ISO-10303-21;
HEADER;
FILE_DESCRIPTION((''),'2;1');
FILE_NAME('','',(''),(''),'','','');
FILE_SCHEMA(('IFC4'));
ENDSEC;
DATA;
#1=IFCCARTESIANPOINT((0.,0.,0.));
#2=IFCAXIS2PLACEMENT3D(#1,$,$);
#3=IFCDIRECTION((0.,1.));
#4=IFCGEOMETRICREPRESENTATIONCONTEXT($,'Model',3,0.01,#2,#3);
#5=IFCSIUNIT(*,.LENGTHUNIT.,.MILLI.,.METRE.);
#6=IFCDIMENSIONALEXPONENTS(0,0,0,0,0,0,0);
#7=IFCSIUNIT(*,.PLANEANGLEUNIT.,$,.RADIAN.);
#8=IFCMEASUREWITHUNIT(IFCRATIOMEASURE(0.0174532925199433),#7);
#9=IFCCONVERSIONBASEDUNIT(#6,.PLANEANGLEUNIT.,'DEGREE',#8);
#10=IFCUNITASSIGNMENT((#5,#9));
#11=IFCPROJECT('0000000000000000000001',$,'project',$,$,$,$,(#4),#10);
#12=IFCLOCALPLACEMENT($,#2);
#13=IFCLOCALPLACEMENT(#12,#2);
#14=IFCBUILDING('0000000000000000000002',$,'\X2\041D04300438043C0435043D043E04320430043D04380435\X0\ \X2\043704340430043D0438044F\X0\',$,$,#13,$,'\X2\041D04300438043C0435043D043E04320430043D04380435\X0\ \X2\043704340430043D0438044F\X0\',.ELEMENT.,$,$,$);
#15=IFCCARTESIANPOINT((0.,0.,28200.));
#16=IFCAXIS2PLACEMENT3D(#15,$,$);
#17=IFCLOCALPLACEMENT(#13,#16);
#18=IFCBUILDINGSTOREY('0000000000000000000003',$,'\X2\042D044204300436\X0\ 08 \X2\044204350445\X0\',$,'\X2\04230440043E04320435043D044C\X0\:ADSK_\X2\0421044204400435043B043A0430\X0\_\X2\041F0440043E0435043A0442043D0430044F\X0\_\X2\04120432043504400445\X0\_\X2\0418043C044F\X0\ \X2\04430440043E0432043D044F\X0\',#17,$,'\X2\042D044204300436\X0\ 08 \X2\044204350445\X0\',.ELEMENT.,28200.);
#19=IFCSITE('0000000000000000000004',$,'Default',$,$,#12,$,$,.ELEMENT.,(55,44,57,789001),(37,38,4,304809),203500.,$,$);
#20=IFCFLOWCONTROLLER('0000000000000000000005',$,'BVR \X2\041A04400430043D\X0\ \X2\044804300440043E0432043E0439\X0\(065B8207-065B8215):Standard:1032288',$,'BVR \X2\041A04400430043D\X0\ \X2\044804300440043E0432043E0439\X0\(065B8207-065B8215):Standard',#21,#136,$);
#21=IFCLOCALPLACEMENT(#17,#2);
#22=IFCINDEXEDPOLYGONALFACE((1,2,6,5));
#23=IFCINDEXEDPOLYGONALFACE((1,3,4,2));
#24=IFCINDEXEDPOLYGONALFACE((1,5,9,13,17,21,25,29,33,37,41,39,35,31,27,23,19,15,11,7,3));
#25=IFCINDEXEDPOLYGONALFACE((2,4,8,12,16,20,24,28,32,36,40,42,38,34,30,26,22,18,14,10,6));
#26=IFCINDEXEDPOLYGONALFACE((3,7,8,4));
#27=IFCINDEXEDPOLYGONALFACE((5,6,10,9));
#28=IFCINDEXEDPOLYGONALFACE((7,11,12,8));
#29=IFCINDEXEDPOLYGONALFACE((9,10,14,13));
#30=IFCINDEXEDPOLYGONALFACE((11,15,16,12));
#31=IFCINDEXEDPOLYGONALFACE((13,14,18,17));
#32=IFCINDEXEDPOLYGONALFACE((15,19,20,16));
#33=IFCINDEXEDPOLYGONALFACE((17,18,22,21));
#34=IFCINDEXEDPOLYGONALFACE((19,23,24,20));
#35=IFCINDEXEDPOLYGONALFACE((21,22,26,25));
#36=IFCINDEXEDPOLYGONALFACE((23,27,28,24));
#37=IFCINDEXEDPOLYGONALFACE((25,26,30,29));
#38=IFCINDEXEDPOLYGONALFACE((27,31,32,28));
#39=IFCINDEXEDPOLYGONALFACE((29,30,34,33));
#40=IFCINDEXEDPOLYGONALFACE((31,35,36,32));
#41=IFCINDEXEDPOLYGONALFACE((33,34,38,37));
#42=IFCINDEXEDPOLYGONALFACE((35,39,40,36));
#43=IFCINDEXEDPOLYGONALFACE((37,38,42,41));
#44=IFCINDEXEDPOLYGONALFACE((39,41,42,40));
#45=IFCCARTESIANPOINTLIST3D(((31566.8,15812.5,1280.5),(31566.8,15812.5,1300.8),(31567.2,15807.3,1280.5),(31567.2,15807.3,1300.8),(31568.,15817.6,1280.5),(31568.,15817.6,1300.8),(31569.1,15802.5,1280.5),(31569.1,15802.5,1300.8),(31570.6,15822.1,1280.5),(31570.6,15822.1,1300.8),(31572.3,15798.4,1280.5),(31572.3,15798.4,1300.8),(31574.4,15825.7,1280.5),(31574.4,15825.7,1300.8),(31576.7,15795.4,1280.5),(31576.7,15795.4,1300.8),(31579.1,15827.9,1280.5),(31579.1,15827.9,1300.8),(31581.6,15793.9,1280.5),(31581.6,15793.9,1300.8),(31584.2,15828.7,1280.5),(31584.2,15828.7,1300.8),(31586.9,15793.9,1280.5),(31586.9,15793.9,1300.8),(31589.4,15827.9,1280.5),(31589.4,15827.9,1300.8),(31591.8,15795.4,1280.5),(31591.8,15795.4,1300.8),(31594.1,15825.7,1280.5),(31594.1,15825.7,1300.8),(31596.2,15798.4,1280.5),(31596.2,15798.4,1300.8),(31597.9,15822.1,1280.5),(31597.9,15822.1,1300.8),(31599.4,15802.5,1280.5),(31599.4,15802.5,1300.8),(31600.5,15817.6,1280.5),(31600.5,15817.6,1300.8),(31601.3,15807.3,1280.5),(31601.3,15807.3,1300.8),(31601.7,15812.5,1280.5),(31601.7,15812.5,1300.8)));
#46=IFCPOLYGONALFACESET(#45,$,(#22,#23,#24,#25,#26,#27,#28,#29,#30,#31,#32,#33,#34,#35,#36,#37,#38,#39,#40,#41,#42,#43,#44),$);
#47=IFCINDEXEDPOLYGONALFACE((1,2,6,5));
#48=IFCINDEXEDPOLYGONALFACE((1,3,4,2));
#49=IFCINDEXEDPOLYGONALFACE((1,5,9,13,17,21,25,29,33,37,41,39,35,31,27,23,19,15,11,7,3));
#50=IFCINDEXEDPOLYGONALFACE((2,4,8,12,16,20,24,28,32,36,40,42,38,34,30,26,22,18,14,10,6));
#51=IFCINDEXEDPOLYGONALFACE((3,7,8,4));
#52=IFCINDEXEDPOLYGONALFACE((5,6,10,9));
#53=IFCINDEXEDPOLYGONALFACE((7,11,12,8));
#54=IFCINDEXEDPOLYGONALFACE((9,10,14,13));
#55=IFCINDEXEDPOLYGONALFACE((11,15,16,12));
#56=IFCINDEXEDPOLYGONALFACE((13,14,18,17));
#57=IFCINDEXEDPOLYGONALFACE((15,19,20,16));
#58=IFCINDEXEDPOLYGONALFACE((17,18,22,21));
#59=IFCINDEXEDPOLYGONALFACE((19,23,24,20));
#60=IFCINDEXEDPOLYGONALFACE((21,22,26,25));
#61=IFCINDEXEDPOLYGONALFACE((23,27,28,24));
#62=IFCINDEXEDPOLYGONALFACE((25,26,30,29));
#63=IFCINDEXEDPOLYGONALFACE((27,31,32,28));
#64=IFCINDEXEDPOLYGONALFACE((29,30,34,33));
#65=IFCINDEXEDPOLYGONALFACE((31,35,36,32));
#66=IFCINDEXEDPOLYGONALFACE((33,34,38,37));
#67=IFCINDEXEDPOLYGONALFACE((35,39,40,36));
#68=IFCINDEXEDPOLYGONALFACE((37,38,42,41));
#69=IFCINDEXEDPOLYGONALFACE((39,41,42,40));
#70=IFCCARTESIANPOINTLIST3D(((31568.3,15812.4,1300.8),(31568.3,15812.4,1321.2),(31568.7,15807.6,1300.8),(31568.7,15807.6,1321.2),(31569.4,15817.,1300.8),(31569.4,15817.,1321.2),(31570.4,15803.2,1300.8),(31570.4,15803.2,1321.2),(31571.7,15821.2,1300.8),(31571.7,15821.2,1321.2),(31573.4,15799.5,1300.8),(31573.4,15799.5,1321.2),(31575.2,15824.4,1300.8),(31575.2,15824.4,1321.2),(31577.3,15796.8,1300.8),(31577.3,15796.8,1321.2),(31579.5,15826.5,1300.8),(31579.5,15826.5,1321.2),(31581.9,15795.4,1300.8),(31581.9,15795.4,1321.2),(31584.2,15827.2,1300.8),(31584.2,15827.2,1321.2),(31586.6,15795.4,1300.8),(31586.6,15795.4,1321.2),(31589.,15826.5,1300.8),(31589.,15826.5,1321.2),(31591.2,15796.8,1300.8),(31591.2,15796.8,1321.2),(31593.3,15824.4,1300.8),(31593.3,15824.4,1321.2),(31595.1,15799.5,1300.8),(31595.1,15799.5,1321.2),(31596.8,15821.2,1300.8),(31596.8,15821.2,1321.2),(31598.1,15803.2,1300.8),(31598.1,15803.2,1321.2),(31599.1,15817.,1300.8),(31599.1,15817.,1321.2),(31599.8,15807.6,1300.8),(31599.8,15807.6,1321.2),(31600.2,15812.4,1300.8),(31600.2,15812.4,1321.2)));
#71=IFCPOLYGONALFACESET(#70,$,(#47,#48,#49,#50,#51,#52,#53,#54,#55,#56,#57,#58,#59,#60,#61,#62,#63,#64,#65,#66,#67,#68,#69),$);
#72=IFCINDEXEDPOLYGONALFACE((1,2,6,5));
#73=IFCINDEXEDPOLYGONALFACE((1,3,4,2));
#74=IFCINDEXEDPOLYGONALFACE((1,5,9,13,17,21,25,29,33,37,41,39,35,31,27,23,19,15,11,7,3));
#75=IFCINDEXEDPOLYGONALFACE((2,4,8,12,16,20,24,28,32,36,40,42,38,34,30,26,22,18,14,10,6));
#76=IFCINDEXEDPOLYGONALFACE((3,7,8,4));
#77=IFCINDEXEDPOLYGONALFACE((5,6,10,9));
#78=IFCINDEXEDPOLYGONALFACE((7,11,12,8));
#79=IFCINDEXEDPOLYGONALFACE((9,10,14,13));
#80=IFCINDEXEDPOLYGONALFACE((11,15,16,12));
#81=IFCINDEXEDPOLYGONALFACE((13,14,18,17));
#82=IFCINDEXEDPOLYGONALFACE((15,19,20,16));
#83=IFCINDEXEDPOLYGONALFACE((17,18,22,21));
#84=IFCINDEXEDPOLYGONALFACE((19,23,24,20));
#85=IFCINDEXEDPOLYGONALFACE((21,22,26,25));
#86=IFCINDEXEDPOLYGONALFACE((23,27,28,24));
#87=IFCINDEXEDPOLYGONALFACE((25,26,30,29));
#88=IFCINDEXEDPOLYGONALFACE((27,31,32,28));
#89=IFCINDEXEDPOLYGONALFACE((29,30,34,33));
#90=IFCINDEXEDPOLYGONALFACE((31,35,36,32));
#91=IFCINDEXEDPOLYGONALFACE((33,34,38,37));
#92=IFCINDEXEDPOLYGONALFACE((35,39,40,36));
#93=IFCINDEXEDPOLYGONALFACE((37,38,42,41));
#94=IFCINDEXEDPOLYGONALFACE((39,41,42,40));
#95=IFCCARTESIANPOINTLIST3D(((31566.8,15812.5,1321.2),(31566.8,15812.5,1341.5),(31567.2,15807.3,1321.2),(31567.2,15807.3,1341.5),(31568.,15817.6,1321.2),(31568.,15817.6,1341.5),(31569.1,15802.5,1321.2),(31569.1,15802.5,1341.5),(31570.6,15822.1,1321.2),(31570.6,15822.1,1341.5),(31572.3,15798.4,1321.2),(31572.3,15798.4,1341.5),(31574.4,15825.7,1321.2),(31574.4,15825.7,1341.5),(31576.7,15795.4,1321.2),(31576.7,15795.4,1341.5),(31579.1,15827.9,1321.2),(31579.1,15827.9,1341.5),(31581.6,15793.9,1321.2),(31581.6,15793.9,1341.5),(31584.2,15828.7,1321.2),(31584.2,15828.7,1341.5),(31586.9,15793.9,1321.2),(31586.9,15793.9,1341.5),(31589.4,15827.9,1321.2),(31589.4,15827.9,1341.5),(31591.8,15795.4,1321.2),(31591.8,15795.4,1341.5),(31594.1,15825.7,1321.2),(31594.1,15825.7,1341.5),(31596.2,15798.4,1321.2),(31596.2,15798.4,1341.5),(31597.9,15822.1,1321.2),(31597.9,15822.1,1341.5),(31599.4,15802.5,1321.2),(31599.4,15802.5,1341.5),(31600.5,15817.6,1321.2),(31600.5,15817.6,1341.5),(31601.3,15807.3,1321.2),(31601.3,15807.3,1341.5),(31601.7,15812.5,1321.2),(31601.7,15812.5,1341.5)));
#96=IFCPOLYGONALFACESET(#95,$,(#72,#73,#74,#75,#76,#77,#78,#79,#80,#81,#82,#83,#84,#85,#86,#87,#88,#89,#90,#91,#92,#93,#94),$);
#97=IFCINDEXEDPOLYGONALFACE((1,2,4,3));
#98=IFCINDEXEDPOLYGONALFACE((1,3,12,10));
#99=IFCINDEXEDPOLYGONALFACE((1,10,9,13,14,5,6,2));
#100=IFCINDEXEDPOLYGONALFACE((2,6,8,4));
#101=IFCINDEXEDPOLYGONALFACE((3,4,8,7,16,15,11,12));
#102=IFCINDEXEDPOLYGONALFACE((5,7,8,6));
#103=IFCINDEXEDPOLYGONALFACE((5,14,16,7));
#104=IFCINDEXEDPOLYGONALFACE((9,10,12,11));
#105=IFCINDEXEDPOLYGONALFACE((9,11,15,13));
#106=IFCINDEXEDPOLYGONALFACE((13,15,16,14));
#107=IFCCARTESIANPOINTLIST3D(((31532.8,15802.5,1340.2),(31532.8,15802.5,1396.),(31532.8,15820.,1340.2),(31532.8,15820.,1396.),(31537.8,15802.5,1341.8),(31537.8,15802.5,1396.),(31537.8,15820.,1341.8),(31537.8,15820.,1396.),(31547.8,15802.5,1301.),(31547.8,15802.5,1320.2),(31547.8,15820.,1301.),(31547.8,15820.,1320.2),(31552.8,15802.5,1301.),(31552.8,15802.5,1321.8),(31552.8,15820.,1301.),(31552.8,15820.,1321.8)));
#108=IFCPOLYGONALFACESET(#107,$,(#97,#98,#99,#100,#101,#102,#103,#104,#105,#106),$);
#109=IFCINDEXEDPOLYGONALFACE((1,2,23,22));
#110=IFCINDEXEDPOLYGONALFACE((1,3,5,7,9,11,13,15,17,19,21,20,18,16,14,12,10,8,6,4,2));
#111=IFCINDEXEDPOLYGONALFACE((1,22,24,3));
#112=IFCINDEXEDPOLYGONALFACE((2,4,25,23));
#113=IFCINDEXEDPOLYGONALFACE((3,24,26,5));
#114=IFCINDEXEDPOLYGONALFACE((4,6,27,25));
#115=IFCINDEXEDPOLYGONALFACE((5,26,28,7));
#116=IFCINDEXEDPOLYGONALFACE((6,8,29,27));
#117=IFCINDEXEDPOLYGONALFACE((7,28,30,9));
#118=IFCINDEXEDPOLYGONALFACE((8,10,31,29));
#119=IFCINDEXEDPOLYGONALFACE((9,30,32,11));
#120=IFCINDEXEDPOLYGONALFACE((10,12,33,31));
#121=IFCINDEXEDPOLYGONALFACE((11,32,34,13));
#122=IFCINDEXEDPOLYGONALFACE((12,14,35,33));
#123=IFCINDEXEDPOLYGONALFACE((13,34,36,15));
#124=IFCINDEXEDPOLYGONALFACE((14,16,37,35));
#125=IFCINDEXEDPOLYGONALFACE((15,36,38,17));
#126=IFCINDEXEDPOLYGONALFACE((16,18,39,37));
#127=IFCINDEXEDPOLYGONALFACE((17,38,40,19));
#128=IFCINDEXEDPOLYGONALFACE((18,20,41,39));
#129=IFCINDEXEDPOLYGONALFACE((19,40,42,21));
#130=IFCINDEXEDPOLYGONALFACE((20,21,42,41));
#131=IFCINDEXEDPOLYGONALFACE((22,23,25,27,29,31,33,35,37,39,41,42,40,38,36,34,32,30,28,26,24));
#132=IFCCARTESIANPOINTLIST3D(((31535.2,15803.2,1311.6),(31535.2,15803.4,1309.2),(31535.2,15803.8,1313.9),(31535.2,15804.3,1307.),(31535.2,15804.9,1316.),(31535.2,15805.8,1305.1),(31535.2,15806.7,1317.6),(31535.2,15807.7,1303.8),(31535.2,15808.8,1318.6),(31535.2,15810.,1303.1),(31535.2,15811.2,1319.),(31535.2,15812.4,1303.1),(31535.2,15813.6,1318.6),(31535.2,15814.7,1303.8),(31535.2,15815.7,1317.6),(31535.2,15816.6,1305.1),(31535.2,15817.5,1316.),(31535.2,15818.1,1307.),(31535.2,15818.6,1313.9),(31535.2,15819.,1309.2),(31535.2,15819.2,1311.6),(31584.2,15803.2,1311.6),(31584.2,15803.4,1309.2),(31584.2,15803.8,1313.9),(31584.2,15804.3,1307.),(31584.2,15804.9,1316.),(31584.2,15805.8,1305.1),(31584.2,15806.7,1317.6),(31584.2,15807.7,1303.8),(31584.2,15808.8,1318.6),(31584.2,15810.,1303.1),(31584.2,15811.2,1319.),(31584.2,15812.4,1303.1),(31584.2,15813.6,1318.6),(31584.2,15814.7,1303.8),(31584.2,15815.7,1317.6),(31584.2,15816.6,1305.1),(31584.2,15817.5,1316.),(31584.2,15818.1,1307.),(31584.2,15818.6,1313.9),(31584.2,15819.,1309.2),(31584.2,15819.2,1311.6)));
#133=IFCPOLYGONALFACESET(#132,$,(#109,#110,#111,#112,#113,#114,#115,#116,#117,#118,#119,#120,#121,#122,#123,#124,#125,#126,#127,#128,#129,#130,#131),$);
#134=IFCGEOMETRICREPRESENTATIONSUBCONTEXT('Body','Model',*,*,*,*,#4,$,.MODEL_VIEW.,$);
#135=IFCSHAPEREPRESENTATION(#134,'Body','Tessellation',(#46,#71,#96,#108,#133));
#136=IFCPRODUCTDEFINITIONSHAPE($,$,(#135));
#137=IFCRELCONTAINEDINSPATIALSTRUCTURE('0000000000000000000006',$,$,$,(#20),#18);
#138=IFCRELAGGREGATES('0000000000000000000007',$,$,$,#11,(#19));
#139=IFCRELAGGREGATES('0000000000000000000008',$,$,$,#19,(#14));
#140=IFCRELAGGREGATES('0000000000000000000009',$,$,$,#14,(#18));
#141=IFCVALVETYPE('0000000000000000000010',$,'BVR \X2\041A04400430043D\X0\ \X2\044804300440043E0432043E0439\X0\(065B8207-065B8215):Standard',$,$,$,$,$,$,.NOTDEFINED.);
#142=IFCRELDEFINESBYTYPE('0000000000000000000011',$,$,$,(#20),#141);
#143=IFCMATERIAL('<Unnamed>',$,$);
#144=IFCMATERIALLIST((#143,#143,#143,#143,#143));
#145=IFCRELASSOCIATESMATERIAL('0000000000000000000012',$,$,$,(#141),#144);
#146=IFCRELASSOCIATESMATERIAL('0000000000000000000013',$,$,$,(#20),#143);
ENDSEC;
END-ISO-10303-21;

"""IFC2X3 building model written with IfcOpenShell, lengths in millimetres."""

from ifc_helpers import new_model, entity, si_unit, converted_unit, direction, frame, origin, origin_2d_with_axis, place, context, subcontext, project, spatial, polyline, circle, outline, extrude, source, transform, mapped, material, material_list, type_object, type_shapes, element, save


model = new_model("IFC2X3")

# Units and contexts
model_context = context("Model", 3, precision=0.01, world=origin(), true_north=direction((0.0, 1.0)))
body_context = subcontext(model_context, "Body", "Model", "MODEL_VIEW")
ifc_project = project(units=[si_unit("LENGTHUNIT", "METRE", prefix="MILLI"), converted_unit("PLANEANGLEUNIT", "DEGREE", entity("IfcRatioMeasure", 0.0174532925199433), si_unit("PLANEANGLEUNIT", "RADIAN"), dimensions=[0, 0, 0, 0, 0, 0, 0])], contexts=[model_context])

# Site, building, storey
site_placement = place(None, origin())
site = spatial("IfcSite", under=ifc_project, at=site_placement, Name="Default", CompositionType="ELEMENT", RefLatitude=(55, 44, 57, 789001), RefLongitude=(37, 38, 4, 304809), RefElevation=203500.0)
building_placement = place(site_placement, origin())
building = spatial("IfcBuilding", under=site, at=building_placement, Name="Наименование здания", LongName="Наименование здания", CompositionType="ELEMENT")
storey_placement = place(building_placement, frame((0.0, 0.0, 28200.0)))
storey = spatial("IfcBuildingStorey", under=building, at=storey_placement, Name="Этаж 08 тех", ObjectType="Уровень:ADSK_Стрелка_Проектная_Вверх_Имя уровня", LongName="Этаж 08 тех", CompositionType="ELEMENT", Elevation=28200.0)

# Flow controller
ifc_material = material(Name="<Unnamed>")
ifc_material_list = material_list([ifc_material, ifc_material, ifc_material, ifc_material, ifc_material])
valve_type = type_object("IfcValveType", Name="BVR Кран шаровой(065B8207-065B8215):Standard", PredefinedType="NOTDEFINED", material=ifc_material_list)
shared_shape_1 = source(origin(), body_context, "Body", "SweptSolid", [
    extrude(circle(Radius=17.5, at=origin_2d_with_axis()), frame((-30.5, 0.0, 0.0), z_axis=(1.0, 0.0, 0.0), x_axis=(0.0, 1.0, 0.0)), (0.0, 0.0, 1.0), 20.3),
    extrude(circle(Radius=16.0, at=origin_2d_with_axis()), frame((-10.2, 0.0, 0.0), z_axis=(1.0, 0.0, 0.0), x_axis=(0.0, 1.0, 0.0)), (0.0, 0.0, 1.0), 20.3),
    extrude(circle(Radius=17.5, at=origin_2d_with_axis()), frame((10.2, 0.0, 0.0), z_axis=(1.0, 0.0, 0.0), x_axis=(0.0, 1.0, 0.0)), (0.0, 0.0, 1.0), 20.3),
    extrude(outline(polyline([(-38.8, -5.0), (-38.8, -10.0), (-17.9, -10.0), (2.1, 5.0), (56.2, 5.0), (56.2, 10.0), (0.4, 10.0), (-19.6, -5.0), (-38.8, -5.0)])), frame((28.8, -8.8, 41.5), z_axis=(0.0, -1.0, 0.0), x_axis=(1.0, 0.0, 0.0)), (0.0, 0.0, -1.0), 17.5),
    extrude(circle(Radius=8.0, at=origin_2d_with_axis()), origin(), (0.0, 0.0, 1.0), 49.0),
])
type_shapes(valve_type, [shared_shape_1])
for number, where, z_axis, x_axis, name in (
    (1, (31584.2, 15811.2, 1311.0), (-1.0, 0.0, 0.0), (0.0, 0.0, 1.0), "BVR Кран шаровой(065B8207-065B8215):Standard:1032288"),
):
    element("IfcFlowController", number, at=place(storey_placement, frame(where, z_axis=z_axis, x_axis=x_axis)), inside=storey, type_object=valve_type, material=ifc_material, Name=name, ObjectType="BVR Кран шаровой(065B8207-065B8215):Standard", context=body_context, shape_type="MappedRepresentation", body=[
        mapped(shared_shape_1, transform((0.0, 0.0, 0.0), scale=1.0)),
    ])

save(model, "model.ifc")
